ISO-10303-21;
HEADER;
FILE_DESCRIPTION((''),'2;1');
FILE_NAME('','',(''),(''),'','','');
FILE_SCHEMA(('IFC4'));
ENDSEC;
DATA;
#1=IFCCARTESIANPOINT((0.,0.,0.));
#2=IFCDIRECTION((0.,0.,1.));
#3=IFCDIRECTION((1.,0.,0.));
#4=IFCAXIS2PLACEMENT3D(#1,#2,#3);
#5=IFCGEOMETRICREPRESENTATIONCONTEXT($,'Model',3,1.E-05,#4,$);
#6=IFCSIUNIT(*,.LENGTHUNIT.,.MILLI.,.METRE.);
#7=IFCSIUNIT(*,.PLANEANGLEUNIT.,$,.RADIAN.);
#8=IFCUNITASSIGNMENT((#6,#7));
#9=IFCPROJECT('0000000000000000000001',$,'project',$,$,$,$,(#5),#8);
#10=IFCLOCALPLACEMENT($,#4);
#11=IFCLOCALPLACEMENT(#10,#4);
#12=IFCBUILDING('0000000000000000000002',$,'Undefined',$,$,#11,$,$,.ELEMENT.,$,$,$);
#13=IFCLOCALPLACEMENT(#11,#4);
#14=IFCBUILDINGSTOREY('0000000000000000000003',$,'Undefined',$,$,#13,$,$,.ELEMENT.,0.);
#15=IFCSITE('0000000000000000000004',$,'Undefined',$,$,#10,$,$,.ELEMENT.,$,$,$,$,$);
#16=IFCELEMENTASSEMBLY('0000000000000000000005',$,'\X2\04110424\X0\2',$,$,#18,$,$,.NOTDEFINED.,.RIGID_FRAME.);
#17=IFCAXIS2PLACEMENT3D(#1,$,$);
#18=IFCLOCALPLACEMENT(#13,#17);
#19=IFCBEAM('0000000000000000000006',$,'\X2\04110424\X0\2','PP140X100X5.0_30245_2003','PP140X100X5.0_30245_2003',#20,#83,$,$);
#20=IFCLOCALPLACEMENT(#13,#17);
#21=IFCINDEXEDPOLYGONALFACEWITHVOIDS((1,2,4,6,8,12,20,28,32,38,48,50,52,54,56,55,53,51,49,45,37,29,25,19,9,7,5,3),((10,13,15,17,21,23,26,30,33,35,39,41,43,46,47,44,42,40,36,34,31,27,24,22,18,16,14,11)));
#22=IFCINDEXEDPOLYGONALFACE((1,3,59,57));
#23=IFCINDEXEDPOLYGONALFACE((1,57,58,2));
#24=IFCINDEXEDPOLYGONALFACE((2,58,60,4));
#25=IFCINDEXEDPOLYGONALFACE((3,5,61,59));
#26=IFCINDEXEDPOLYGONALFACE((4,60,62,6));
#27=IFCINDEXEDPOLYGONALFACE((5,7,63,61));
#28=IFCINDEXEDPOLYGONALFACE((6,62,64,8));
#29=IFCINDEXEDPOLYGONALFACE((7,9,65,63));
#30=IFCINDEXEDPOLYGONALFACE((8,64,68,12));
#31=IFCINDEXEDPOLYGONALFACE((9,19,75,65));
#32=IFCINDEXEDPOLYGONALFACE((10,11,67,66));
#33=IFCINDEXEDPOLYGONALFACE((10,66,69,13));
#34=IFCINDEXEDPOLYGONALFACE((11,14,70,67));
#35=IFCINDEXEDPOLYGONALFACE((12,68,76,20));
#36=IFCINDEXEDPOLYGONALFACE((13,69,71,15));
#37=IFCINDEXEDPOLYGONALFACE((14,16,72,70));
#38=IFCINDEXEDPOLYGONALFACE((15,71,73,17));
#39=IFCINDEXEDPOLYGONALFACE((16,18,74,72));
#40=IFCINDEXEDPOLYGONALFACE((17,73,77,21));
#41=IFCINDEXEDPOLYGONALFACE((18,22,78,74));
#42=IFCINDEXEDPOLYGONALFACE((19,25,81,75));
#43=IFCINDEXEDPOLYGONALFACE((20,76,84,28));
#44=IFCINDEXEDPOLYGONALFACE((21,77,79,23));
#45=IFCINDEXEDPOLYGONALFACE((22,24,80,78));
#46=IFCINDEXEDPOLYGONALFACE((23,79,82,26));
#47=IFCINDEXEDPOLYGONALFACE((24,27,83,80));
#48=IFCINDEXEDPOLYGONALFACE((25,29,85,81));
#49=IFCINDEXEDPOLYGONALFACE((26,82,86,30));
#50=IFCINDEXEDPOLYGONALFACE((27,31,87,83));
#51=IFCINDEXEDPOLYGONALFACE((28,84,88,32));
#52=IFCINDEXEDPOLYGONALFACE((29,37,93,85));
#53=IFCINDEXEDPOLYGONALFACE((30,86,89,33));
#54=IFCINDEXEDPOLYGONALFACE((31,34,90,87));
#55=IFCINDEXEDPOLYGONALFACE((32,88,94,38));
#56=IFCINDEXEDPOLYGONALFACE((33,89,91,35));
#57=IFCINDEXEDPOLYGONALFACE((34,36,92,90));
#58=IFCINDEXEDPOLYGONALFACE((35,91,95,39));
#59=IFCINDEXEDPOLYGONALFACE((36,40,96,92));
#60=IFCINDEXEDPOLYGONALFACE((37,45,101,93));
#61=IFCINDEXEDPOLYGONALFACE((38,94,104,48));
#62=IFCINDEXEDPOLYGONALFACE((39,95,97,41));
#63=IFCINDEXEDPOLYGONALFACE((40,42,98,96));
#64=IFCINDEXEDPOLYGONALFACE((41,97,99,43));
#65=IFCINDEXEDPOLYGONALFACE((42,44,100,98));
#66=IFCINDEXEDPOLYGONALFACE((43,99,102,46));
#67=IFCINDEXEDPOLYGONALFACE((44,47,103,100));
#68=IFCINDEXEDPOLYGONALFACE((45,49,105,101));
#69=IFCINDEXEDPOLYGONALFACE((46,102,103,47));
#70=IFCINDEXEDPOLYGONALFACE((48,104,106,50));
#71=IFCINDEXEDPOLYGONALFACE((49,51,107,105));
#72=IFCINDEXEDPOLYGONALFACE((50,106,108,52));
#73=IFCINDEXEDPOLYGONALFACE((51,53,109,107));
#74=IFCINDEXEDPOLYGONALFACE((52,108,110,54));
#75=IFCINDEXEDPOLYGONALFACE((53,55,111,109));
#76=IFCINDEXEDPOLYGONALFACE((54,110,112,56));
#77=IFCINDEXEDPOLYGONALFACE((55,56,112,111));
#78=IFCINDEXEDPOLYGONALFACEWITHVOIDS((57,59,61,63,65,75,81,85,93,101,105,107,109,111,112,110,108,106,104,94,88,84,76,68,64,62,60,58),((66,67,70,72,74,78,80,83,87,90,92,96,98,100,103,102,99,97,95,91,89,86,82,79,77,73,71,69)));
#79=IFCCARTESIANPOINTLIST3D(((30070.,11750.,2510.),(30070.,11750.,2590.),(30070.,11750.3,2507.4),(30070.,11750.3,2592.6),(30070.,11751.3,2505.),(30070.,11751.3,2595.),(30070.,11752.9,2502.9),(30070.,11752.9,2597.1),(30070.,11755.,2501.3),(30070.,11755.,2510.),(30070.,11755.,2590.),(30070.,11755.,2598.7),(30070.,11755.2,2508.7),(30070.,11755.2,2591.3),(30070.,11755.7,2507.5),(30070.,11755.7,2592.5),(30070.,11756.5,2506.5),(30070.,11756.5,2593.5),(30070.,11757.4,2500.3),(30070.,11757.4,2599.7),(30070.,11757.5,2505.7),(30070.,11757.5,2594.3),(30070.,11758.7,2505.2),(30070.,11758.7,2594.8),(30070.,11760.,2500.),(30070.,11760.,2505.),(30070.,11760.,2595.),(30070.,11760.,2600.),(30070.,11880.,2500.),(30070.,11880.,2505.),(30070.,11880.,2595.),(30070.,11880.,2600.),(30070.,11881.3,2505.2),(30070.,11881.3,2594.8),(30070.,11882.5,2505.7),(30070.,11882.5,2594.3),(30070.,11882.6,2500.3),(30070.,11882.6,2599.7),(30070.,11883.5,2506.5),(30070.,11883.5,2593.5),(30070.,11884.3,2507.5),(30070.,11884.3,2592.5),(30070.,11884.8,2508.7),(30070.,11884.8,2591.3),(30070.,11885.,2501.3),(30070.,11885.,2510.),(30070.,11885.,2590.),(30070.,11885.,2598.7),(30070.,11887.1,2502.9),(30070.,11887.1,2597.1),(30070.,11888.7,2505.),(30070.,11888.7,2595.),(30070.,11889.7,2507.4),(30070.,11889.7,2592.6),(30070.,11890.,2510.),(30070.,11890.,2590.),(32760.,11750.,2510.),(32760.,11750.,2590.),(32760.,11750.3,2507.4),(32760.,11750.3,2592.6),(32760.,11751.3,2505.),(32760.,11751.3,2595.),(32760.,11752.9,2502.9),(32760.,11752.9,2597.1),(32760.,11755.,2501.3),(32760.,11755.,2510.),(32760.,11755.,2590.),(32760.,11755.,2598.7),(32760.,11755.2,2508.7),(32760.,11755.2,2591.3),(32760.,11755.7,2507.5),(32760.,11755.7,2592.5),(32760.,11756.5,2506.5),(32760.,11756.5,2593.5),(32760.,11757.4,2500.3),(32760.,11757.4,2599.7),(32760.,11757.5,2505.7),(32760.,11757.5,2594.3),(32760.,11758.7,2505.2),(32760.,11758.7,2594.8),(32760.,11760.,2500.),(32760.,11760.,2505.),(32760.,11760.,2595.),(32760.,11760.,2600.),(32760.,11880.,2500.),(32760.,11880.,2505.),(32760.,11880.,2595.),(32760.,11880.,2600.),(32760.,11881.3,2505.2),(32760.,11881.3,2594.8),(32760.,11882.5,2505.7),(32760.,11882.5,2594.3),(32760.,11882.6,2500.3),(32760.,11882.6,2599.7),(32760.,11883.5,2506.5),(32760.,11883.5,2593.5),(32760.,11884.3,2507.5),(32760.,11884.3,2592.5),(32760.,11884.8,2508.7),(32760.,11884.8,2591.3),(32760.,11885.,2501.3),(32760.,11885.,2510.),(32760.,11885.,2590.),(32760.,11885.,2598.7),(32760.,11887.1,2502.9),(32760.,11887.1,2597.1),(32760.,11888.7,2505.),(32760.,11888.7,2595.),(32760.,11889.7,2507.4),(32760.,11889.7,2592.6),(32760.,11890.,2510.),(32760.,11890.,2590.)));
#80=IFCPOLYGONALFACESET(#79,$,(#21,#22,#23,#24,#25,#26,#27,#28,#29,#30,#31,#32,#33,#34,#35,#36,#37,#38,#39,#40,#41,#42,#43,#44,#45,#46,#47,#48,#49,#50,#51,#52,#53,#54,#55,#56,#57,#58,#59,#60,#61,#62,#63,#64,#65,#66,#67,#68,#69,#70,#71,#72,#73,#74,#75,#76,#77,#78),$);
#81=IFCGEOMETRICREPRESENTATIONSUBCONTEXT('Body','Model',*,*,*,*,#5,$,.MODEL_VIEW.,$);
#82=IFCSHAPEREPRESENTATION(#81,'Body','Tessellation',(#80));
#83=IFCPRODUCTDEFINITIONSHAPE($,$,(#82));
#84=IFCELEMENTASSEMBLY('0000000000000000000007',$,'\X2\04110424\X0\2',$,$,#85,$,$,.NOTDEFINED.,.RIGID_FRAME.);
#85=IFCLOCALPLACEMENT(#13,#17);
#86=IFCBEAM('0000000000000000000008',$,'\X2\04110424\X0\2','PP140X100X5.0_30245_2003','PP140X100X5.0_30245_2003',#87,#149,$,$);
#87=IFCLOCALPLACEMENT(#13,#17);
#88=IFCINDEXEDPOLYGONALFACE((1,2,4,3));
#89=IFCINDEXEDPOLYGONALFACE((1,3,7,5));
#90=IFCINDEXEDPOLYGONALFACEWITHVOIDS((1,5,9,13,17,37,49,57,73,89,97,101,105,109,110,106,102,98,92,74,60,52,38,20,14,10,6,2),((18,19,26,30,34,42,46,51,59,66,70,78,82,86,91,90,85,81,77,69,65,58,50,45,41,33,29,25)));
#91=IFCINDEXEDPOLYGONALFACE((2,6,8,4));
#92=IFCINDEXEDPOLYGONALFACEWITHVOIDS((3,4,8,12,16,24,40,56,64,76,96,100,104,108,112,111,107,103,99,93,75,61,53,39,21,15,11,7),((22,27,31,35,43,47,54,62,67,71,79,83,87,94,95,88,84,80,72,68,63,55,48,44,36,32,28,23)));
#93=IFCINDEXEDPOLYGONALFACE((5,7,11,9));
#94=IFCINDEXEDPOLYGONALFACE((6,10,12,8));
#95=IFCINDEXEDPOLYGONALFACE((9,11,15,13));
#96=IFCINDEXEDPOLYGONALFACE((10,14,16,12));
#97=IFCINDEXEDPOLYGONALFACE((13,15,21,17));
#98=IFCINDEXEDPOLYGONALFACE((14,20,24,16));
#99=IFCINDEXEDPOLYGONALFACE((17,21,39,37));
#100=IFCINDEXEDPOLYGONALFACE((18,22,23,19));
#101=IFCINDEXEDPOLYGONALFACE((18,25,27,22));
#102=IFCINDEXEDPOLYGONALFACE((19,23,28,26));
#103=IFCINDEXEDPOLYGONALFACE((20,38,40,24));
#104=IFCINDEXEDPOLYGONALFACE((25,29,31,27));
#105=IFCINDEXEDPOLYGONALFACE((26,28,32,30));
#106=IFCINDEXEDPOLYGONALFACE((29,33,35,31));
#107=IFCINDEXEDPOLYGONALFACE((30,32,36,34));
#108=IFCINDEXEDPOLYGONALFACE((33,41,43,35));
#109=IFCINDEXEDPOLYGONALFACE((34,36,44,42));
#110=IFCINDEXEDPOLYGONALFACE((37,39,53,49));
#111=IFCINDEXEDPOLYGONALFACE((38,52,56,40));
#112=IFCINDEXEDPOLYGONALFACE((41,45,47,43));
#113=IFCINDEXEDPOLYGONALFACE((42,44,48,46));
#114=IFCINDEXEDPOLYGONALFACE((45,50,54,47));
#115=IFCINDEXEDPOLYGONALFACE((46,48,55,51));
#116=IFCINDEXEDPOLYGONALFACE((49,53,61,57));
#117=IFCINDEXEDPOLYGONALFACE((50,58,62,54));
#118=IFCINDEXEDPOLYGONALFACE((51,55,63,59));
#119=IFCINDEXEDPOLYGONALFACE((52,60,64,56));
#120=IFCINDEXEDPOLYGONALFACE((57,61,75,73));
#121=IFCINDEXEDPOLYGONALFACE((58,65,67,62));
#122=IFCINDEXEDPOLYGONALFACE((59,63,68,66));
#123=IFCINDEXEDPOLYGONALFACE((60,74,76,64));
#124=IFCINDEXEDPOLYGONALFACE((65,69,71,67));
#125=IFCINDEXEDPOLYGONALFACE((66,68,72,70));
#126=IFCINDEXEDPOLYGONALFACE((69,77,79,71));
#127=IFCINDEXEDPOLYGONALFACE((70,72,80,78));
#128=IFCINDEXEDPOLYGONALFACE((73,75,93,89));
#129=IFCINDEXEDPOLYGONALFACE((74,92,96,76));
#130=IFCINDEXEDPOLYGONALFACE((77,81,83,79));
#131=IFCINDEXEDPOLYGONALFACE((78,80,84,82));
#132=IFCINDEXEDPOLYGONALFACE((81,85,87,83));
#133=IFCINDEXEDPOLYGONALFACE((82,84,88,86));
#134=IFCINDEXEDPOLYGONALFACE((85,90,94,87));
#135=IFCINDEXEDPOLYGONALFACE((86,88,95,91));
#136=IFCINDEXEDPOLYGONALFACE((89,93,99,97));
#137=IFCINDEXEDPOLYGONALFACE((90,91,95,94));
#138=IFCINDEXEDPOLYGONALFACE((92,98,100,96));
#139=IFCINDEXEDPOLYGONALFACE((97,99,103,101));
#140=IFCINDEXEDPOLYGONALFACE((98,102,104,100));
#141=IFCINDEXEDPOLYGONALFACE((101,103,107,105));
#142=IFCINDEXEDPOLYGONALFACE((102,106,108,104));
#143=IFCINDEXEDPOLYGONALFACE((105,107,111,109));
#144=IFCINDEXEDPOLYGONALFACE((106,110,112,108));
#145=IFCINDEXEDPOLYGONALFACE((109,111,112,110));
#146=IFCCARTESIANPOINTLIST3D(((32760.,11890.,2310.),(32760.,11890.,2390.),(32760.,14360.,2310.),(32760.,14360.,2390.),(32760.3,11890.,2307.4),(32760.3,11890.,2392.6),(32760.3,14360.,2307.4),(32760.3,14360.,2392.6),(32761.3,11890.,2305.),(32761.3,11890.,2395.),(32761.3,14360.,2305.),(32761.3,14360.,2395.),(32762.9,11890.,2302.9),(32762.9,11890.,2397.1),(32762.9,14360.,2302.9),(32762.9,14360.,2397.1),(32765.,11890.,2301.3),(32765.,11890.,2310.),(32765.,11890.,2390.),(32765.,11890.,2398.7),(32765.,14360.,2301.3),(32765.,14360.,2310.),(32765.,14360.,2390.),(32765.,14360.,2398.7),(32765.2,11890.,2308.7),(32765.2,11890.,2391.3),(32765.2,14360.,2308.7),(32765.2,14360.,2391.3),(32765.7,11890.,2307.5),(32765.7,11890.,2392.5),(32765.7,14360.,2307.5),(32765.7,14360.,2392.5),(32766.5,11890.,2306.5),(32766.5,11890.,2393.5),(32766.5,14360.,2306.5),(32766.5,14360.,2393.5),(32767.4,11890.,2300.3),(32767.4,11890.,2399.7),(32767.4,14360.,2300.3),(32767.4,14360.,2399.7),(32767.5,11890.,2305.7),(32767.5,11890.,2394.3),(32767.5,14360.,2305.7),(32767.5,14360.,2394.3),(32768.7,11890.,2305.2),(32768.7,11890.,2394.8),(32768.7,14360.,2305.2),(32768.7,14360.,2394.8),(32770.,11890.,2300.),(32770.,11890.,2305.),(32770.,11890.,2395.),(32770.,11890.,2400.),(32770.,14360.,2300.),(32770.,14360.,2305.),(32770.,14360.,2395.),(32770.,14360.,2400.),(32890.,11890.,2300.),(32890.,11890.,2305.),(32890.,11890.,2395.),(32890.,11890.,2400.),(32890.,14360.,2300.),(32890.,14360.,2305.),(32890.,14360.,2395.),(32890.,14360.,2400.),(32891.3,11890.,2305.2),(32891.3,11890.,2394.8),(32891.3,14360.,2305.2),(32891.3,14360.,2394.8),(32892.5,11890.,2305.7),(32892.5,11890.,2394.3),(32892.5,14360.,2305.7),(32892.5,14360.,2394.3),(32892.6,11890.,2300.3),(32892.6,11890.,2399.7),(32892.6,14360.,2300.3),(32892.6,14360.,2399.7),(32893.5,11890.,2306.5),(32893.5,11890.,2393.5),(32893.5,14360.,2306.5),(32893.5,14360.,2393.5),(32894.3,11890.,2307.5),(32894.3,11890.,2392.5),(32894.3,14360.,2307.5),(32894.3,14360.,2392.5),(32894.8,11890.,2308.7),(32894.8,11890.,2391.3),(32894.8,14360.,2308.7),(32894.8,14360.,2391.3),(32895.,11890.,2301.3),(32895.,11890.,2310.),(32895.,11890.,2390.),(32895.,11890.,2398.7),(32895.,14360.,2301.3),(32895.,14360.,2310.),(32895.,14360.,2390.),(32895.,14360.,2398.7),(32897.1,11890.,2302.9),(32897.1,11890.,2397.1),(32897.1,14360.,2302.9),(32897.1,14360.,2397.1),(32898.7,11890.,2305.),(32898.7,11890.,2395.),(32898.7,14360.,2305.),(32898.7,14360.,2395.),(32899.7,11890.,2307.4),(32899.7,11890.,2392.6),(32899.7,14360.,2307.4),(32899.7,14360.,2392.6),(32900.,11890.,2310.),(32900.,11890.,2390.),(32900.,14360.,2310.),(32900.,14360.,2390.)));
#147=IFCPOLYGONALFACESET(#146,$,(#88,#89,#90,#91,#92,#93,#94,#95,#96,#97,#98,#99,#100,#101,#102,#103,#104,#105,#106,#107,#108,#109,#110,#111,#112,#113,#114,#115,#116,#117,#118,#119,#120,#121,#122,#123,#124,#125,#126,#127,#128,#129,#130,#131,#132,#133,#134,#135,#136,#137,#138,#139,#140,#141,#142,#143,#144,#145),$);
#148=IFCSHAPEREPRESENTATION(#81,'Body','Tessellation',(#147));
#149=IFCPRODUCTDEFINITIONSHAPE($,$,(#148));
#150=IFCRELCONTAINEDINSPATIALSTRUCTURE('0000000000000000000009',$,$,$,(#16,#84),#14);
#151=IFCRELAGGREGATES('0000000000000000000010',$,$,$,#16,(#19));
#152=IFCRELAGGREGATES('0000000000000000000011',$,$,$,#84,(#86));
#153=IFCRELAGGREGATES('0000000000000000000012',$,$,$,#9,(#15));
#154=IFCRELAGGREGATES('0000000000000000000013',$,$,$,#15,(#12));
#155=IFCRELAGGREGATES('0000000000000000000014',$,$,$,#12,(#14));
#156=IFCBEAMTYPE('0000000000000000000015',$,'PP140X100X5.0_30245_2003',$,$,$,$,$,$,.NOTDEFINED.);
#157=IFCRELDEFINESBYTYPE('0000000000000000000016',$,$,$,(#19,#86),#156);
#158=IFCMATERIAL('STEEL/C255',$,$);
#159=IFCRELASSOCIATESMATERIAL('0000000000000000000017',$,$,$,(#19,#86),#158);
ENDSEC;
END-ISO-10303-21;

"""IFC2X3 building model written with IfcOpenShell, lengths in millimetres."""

from ifc_helpers import new_model, si_unit, frame, origin_with_axes, origin_2d_with_axis, place, context, subcontext, project, spatial, hollow_rectangle, extrude, material, type_object, element, aggregate, save


model = new_model("IFC2X3")

# Units and contexts
model_context = context("Model", 3, precision=1e-05, world=origin_with_axes())
body_context = subcontext(model_context, "Body", "Model", "MODEL_VIEW")
ifc_project = project(units=[si_unit("LENGTHUNIT", "METRE", prefix="MILLI"), si_unit("PLANEANGLEUNIT", "RADIAN")], contexts=[model_context])

# Site, building, storey
site_placement = place(None, origin_with_axes())
site = spatial("IfcSite", under=ifc_project, at=site_placement, Name="Undefined", CompositionType="ELEMENT")
building_placement = place(site_placement, origin_with_axes())
building = spatial("IfcBuilding", under=site, at=building_placement, Name="Undefined", CompositionType="ELEMENT")
storey_placement = place(building_placement, origin_with_axes())
storey = spatial("IfcBuildingStorey", under=building, at=storey_placement, Name="Undefined", CompositionType="ELEMENT", Elevation=0.0)

# Shared definitions
ifc_material_1 = material(Name="STEEL/C255")

# Element assemblies, beams
assembly_1_placement = place(storey_placement, origin_with_axes())
assembly_1 = element("IfcElementAssembly", 1, at=assembly_1_placement, inside=storey, Name="БФ2", AssemblyPlace="NOTDEFINED", PredefinedType="RIGID_FRAME")
beam_type_1 = type_object("IfcBeamType", Name="PP140X100X5.0_30245_2003", PredefinedType="NOTDEFINED")
beam_1_placement = place(assembly_1_placement, frame((32760.0, 11820.0, 2550.0), z_axis=(0.0, 1.0, 0.0), x_axis=(-1.0, 0.0, 0.0)))
beam_1 = element("IfcBeam", 2, at=beam_1_placement, type_object=beam_type_1, material=ifc_material_1, Name="БФ2", Description="PP140X100X5.0_30245_2003", ObjectType="PP140X100X5.0_30245_2003", context=body_context, shape_type="SweptSolid", body=[
    extrude(hollow_rectangle(XDim=100.0, YDim=140.0, WallThickness=5.0, InnerFilletRadius=5.0, OuterFilletRadius=10.0, at=origin_2d_with_axis()), frame((2690.0, 0.0, 0.0), z_axis=(-1.0, 0.0, 0.0), x_axis=(0.0, -1.0, 0.0)), (0.0, 0.0, 1.0), 2690.0),
])
aggregate(assembly_1, [beam_1])
assembly_2_placement = place(storey_placement, origin_with_axes())
assembly_2 = element("IfcElementAssembly", 3, at=assembly_2_placement, inside=storey, Name="БФ2", AssemblyPlace="NOTDEFINED", PredefinedType="RIGID_FRAME")
beam_2_placement = place(assembly_2_placement, frame((32830.0, 11890.0, 2350.0), z_axis=(1.0, 0.0, 0.0), x_axis=(0.0, 1.0, 0.0)))
beam_2 = element("IfcBeam", 4, at=beam_2_placement, type_object=beam_type_1, material=ifc_material_1, Name="БФ2", Description="PP140X100X5.0_30245_2003", ObjectType="PP140X100X5.0_30245_2003", context=body_context, shape_type="SweptSolid", body=[
    extrude(hollow_rectangle(XDim=100.0, YDim=140.0, WallThickness=5.0, InnerFilletRadius=5.0, OuterFilletRadius=10.0, at=origin_2d_with_axis()), frame((2470.0, 0.0, 0.0), z_axis=(-1.0, 0.0, 0.0), x_axis=(0.0, -1.0, 0.0)), (0.0, 0.0, 1.0), 2470.0),
])
aggregate(assembly_2, [beam_2])

save(model, "model.ifc")
